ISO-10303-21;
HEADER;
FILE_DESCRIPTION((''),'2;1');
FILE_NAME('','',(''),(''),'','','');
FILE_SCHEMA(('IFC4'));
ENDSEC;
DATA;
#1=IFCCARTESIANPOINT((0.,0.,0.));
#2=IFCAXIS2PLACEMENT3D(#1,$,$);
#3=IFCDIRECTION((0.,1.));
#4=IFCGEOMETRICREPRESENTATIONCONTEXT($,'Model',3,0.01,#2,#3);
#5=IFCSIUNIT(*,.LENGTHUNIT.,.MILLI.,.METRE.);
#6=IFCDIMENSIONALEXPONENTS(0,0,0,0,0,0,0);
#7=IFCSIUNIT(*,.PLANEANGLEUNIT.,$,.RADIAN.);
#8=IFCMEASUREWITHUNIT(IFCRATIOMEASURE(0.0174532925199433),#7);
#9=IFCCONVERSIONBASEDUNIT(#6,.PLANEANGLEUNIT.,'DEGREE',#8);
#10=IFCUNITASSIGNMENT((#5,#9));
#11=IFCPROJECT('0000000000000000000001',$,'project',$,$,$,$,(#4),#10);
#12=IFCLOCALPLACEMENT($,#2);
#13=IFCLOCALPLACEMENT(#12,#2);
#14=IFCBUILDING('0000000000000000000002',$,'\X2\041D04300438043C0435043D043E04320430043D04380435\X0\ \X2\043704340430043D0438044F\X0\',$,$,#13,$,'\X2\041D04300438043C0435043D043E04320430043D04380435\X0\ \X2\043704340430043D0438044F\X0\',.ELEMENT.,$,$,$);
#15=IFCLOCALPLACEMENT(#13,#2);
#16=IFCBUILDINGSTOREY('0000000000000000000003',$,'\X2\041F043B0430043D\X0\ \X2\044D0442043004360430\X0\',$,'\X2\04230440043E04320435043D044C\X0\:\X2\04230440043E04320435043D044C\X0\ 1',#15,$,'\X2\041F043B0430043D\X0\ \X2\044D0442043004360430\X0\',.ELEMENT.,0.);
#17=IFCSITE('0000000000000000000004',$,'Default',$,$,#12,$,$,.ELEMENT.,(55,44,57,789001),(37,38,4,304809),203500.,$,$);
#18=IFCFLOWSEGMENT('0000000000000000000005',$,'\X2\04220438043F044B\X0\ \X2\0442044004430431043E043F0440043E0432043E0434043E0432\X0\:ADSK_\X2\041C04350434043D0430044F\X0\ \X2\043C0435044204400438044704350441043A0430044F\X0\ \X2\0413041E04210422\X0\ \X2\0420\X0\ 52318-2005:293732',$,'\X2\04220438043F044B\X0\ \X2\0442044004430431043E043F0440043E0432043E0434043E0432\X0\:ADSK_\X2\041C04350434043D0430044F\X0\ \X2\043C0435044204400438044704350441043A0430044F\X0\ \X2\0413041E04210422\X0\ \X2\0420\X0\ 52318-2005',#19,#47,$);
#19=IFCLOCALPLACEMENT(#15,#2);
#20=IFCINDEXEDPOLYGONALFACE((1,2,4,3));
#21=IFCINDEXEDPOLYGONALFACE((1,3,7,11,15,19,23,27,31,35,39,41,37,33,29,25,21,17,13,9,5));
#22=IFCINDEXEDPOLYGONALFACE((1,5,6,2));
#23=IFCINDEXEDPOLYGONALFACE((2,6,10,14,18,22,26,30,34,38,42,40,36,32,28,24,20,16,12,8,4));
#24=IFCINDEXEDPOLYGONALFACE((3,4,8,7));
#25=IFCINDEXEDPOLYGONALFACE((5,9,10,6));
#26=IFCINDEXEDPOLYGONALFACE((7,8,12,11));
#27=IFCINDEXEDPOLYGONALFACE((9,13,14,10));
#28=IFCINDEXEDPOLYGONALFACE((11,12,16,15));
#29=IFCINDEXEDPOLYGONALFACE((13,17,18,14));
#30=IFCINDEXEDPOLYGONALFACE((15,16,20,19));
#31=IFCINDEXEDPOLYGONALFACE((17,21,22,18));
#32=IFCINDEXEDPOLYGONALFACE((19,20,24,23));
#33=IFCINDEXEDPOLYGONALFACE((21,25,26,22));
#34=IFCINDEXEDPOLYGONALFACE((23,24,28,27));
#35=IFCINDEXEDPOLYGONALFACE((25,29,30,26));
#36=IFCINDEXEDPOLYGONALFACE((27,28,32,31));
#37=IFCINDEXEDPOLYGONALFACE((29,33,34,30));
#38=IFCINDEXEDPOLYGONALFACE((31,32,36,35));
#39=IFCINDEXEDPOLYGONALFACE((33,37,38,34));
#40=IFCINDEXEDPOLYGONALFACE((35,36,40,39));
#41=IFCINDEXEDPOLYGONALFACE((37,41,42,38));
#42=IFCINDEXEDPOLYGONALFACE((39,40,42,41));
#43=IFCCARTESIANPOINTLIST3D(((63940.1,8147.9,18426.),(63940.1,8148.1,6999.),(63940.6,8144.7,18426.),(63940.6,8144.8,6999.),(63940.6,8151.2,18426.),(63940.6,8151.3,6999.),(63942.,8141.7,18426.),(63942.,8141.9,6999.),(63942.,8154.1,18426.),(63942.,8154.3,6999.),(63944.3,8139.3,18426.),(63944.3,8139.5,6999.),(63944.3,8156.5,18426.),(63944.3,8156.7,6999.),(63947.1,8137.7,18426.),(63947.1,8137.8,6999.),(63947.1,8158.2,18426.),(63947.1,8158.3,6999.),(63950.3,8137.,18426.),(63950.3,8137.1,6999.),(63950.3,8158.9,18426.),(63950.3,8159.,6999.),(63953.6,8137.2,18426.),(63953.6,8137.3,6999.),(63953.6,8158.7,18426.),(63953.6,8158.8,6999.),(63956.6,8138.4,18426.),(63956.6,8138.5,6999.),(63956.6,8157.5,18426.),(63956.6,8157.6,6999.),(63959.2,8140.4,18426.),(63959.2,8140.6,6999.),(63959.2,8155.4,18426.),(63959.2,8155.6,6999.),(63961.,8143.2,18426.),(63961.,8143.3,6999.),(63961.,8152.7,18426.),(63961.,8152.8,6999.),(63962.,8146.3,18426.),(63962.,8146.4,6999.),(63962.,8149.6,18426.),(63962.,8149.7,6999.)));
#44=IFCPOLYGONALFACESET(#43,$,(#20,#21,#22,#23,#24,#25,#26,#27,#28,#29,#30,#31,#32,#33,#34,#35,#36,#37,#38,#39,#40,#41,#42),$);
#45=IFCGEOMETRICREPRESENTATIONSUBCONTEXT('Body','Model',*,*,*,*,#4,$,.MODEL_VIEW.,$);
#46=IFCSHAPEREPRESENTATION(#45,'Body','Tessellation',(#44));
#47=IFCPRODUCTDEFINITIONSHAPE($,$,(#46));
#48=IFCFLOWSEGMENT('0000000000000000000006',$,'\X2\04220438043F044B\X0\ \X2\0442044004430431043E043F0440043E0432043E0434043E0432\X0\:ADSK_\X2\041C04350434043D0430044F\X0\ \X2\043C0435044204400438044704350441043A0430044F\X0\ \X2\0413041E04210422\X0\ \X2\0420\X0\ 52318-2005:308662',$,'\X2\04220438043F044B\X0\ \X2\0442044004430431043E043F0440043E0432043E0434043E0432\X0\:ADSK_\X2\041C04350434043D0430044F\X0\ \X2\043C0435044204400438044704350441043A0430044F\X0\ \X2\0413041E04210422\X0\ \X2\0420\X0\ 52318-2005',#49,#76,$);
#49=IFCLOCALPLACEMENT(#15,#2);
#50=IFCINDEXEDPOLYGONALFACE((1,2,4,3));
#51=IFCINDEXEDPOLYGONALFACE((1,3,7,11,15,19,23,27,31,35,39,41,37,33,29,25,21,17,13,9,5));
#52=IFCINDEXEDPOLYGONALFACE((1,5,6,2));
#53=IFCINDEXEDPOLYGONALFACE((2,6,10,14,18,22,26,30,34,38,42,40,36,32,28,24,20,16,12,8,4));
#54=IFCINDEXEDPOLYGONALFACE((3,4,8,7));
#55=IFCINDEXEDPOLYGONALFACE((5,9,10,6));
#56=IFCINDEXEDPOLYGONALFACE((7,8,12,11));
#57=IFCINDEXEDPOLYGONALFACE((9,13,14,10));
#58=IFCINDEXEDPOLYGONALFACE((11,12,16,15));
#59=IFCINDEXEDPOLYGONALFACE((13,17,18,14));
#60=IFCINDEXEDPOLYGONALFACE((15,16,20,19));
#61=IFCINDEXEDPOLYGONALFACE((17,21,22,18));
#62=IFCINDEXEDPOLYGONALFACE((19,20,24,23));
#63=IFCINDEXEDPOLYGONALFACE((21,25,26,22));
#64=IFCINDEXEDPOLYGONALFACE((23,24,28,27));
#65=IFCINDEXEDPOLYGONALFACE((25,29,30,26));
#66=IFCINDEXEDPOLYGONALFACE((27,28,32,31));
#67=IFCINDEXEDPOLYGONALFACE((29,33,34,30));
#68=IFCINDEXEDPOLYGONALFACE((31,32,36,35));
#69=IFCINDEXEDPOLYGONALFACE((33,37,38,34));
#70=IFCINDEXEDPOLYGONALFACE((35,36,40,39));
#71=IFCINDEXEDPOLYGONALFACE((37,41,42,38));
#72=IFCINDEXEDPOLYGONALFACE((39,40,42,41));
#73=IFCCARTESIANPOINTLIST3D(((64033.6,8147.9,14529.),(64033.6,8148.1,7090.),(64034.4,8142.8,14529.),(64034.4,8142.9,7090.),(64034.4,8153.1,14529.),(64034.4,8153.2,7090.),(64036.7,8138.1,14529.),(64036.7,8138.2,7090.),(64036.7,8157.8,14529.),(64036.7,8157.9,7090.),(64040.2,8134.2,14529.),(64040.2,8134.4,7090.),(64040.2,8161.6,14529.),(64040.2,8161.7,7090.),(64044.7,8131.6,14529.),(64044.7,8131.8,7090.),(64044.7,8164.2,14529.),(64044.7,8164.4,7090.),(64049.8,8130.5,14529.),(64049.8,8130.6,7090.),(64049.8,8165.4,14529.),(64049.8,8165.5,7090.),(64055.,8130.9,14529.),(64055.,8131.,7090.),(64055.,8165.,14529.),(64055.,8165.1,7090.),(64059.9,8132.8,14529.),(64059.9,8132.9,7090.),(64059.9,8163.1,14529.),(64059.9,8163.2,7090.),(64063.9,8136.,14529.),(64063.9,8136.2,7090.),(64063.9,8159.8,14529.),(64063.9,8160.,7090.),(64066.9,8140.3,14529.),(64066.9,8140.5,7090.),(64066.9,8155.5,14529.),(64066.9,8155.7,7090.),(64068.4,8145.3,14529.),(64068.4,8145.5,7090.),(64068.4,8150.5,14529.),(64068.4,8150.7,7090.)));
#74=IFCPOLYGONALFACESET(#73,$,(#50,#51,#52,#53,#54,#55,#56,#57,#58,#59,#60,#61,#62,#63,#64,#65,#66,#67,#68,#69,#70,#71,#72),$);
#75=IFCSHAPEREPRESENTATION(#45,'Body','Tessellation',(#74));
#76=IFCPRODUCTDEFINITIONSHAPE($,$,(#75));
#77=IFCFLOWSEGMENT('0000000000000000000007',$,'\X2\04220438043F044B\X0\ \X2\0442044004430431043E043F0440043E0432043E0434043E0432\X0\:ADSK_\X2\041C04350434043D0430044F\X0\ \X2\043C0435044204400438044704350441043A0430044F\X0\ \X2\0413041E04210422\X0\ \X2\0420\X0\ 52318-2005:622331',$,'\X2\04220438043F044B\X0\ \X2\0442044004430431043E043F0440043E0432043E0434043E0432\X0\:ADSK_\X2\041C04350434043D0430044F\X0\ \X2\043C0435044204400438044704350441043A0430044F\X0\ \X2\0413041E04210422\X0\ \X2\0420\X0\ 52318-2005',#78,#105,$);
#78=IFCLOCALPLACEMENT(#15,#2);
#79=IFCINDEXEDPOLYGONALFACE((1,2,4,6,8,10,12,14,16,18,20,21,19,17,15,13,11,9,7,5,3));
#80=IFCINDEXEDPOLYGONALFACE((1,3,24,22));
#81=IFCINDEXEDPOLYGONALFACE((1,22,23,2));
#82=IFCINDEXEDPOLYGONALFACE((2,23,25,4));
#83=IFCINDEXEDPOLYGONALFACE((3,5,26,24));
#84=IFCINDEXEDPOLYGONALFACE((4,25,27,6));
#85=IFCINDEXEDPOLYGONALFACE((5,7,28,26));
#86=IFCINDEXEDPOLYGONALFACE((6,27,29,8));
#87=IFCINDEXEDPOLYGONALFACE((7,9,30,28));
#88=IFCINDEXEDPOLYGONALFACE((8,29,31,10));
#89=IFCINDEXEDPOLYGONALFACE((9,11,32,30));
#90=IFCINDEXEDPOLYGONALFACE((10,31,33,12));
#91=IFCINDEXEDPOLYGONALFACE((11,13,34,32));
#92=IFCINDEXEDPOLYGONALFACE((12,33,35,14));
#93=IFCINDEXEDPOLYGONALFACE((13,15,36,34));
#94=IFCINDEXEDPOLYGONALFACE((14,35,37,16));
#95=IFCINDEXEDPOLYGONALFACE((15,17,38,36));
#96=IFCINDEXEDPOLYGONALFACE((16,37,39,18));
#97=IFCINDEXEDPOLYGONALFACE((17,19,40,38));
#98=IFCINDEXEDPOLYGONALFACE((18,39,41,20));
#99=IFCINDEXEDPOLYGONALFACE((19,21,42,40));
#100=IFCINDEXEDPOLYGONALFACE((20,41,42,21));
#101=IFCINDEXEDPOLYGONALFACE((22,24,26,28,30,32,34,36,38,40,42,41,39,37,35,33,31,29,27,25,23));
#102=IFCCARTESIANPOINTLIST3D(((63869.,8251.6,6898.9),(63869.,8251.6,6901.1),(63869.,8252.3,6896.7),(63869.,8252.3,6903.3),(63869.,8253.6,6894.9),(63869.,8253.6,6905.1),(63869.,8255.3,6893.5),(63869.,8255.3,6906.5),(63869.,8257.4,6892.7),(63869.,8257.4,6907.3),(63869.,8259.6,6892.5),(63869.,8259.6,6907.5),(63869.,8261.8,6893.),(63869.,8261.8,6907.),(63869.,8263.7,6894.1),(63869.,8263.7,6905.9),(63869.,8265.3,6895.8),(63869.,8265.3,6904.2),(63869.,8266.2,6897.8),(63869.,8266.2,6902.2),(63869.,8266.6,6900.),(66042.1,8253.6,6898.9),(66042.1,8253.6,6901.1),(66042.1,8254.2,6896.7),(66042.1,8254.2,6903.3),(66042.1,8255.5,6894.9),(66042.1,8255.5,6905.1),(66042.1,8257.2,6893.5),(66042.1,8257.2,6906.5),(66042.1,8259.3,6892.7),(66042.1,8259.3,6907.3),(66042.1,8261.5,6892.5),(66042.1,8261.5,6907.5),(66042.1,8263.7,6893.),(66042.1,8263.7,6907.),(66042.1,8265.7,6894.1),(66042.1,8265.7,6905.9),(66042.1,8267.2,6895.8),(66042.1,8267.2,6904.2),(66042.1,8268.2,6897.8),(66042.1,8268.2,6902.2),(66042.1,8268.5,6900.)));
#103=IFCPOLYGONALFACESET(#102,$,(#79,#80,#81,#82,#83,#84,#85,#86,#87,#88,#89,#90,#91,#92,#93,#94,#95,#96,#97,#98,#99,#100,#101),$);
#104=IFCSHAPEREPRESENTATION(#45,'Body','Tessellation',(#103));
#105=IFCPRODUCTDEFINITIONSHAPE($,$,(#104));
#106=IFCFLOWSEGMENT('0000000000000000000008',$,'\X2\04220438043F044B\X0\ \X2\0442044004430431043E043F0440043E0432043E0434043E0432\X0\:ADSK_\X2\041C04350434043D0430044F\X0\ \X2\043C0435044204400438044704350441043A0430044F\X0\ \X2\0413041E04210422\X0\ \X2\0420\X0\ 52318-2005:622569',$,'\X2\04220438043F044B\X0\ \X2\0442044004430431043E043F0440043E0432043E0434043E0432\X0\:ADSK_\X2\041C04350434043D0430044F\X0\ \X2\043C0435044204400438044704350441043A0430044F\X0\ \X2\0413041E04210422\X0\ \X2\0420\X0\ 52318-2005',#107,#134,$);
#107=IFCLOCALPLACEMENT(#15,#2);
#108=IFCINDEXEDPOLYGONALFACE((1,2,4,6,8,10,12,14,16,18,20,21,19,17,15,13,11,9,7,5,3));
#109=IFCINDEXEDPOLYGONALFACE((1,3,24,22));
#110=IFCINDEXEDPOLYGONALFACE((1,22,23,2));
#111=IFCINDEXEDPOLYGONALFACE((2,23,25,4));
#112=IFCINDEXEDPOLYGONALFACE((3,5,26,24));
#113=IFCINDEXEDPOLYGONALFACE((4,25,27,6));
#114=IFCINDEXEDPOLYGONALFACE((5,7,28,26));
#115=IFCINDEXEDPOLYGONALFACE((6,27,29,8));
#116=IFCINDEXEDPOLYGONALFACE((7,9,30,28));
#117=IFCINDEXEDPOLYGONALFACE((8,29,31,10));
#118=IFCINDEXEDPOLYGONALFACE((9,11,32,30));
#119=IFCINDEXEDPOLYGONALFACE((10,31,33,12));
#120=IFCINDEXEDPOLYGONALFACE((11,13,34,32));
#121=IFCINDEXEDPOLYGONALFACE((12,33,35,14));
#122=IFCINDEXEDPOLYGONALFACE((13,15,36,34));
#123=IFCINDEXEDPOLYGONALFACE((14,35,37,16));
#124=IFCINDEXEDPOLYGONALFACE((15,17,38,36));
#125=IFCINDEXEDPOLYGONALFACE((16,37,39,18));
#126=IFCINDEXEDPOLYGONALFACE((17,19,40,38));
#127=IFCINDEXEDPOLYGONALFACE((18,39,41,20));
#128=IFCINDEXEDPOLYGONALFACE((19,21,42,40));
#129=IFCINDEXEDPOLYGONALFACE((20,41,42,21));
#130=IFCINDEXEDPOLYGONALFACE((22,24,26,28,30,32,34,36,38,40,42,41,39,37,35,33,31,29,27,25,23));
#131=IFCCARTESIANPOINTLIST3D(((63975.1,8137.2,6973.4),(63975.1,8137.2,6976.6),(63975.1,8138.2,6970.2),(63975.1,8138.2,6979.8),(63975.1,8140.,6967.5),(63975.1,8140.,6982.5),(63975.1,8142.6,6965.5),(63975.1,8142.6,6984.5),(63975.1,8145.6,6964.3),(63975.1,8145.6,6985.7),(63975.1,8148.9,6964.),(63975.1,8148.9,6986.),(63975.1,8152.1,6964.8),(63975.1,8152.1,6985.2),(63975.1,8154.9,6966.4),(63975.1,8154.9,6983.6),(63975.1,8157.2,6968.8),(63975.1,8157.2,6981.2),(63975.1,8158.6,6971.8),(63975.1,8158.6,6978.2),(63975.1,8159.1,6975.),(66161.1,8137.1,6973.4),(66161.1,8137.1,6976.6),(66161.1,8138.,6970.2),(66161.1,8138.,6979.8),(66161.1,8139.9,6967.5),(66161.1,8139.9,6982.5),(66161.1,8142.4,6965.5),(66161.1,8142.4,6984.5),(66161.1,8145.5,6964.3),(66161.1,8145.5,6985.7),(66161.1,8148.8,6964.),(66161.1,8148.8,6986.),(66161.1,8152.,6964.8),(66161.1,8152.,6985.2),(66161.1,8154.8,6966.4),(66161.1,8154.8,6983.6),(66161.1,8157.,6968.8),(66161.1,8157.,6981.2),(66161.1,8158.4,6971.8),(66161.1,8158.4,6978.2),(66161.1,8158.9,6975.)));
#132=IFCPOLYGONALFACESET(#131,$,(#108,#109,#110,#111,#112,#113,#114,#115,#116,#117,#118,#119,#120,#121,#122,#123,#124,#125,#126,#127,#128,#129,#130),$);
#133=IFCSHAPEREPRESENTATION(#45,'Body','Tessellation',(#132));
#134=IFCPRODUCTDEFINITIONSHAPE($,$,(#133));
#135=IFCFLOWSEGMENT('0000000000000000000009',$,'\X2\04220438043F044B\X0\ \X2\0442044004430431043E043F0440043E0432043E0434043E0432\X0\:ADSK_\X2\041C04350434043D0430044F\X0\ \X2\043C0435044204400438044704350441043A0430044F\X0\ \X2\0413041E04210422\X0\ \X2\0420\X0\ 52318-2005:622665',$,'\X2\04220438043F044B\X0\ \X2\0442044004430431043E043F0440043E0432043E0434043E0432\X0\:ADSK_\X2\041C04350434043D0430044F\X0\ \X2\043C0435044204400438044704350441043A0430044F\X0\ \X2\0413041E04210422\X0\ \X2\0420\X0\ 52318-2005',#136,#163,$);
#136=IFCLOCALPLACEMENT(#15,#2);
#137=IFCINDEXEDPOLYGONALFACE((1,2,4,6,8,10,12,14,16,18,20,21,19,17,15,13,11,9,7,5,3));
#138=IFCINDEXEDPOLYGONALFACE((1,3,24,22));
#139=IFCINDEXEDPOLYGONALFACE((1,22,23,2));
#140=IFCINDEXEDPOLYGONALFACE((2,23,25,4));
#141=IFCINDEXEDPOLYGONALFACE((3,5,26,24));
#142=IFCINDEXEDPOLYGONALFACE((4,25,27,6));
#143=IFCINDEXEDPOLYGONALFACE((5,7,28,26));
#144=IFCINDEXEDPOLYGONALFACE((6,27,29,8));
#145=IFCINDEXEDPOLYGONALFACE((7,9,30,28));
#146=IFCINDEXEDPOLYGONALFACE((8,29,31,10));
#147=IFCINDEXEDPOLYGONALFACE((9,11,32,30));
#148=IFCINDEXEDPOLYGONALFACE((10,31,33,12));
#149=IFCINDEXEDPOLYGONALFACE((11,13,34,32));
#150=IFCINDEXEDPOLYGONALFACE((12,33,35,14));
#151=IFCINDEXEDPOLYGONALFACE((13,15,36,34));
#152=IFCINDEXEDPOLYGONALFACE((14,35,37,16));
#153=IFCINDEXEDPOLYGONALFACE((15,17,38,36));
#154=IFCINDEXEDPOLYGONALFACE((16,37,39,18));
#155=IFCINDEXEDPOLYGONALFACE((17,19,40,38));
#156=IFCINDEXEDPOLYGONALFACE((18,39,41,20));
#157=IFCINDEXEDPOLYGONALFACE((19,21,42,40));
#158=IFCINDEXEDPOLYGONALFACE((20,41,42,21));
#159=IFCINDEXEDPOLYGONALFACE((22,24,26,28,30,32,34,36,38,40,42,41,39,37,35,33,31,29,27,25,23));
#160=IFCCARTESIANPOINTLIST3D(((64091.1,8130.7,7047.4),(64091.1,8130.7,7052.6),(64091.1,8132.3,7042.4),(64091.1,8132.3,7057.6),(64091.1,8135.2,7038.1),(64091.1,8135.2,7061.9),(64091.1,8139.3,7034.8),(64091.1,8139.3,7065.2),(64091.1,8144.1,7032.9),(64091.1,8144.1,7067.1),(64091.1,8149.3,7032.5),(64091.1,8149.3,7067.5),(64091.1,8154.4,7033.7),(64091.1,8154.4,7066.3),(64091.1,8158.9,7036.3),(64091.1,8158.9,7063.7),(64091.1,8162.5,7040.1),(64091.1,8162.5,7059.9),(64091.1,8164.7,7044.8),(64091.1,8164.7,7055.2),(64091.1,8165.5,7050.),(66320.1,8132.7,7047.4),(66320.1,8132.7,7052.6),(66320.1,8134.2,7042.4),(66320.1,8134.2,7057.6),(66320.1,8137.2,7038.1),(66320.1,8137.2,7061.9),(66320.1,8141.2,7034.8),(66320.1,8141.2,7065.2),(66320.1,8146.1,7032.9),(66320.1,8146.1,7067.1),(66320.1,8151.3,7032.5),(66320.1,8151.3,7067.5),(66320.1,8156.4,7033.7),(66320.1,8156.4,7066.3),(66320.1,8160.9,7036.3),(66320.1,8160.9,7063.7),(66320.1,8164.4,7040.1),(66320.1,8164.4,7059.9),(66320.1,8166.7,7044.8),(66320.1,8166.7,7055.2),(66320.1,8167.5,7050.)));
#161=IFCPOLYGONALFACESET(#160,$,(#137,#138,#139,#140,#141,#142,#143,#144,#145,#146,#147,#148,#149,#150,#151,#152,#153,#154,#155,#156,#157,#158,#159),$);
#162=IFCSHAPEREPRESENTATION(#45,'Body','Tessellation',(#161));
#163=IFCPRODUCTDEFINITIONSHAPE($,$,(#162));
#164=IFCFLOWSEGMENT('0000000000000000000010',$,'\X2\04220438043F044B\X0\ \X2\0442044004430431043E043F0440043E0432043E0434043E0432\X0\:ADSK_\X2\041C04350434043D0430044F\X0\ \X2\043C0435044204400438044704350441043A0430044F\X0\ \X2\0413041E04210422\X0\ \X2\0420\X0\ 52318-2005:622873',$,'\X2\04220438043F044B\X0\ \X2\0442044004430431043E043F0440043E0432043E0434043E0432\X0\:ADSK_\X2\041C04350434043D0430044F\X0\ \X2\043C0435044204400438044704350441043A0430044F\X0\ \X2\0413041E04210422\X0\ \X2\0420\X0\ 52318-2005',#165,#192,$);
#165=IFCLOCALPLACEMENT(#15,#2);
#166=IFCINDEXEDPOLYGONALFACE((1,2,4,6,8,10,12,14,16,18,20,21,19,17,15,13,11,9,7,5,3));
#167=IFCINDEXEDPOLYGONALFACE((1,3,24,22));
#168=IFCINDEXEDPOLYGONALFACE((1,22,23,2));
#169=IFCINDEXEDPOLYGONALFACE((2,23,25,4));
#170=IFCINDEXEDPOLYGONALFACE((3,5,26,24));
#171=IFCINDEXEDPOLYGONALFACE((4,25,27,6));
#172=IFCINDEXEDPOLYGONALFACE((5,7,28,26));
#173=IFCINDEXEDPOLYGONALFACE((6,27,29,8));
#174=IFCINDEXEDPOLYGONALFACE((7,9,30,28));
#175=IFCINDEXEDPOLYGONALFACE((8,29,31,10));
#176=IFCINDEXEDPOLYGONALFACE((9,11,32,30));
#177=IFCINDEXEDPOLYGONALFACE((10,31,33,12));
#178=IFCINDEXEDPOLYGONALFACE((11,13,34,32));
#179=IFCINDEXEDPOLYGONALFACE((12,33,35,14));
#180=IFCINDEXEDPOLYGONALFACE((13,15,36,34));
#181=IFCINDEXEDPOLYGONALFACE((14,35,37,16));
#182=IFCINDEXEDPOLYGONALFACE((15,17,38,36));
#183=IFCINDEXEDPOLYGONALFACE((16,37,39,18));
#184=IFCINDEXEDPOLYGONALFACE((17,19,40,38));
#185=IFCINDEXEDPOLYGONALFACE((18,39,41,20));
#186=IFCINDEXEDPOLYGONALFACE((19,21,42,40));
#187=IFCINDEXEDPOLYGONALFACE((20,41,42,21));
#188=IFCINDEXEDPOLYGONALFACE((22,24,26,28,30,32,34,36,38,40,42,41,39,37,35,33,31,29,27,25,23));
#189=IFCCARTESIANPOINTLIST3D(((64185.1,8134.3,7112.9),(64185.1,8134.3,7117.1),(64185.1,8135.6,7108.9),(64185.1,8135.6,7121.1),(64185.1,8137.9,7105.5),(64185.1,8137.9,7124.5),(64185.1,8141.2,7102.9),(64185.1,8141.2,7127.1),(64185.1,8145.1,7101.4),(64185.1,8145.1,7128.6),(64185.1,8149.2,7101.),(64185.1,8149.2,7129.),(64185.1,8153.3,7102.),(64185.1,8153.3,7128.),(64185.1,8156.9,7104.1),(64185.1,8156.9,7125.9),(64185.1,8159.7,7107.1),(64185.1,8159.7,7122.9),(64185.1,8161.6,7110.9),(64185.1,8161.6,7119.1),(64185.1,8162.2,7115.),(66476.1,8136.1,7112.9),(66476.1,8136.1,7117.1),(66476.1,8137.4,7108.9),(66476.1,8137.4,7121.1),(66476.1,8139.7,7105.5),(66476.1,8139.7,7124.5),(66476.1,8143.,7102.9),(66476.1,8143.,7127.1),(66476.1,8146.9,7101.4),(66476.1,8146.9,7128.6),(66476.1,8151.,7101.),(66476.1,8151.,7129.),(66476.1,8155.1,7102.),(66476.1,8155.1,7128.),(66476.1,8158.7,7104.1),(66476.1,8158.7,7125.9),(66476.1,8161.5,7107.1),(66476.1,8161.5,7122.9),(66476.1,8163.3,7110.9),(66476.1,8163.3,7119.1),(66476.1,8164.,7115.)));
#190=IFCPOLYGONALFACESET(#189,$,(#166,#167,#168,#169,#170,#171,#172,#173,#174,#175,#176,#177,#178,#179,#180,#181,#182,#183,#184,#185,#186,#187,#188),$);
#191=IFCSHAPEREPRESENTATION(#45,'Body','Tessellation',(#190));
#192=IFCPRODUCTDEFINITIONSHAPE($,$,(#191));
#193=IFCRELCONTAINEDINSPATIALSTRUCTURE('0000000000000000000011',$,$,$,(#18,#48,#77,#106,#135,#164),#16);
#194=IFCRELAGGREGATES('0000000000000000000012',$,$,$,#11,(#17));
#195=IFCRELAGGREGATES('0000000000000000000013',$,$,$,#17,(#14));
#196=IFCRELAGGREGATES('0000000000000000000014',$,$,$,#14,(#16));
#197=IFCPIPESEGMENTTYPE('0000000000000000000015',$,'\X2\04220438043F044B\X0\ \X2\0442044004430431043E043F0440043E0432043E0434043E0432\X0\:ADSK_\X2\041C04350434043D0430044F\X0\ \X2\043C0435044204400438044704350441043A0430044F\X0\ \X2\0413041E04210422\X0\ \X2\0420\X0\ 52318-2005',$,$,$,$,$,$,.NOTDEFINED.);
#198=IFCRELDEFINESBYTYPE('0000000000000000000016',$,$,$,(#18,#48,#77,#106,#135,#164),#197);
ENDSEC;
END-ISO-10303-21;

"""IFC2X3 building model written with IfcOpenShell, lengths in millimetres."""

from ifc_helpers import new_model, entity, si_unit, converted_unit, direction, frame, frame_2d, origin, origin_2d_with_axis, place, context, subcontext, project, spatial, circle, extrude, type_object, element, save


model = new_model("IFC2X3")

# Units and contexts
model_context = context("Model", 3, precision=0.01, world=origin(), true_north=direction((0.0, 1.0)))
body_context = subcontext(model_context, "Body", "Model", "MODEL_VIEW")
ifc_project = project(units=[si_unit("LENGTHUNIT", "METRE", prefix="MILLI"), converted_unit("PLANEANGLEUNIT", "DEGREE", entity("IfcRatioMeasure", 0.0174532925199433), si_unit("PLANEANGLEUNIT", "RADIAN"), dimensions=[0, 0, 0, 0, 0, 0, 0])], contexts=[model_context])

# Site, building, storey
site_placement = place(None, frame((0.0, 0.0, 0.0)))
site = spatial("IfcSite", under=ifc_project, at=site_placement, Name="Default", CompositionType="ELEMENT", RefLatitude=(55, 44, 57, 789001), RefLongitude=(37, 38, 4, 304809), RefElevation=203500.0)
building_placement = place(site_placement, origin())
building = spatial("IfcBuilding", under=site, at=building_placement, Name="Наименование здания", LongName="Наименование здания", CompositionType="ELEMENT")
storey_placement = place(building_placement, origin())
storey = spatial("IfcBuildingStorey", under=building, at=storey_placement, Name="План этажа", ObjectType="Уровень:Уровень 1", LongName="План этажа", CompositionType="ELEMENT", Elevation=0.0)

# Flow segments
pipe_segment_type = type_object("IfcPipeSegmentType", Name="Типы трубопроводов:ADSK_Медная метрическая ГОСТ Р 52318-2005", PredefinedType="NOTDEFINED")
flow_segment_1_placement = place(building_placement, frame((63938.5, 8135.3, 6999.0)))
element("IfcFlowSegment", 1, at=flow_segment_1_placement, inside=storey, type_object=pipe_segment_type, Name="Типы трубопроводов:ADSK_Медная метрическая ГОСТ Р 52318-2005:293732", ObjectType="Типы трубопроводов:ADSK_Медная метрическая ГОСТ Р 52318-2005", context=body_context, shape_type="SweptSolid", body=[
    extrude(circle(Radius=11.0, at=origin_2d_with_axis()), frame((12.6, 12.7, 0.0), z_axis=(0.0, -0.000012, 1.0), x_axis=(-1.0, 0.0, 0.0)), (0.0, 0.0, 1.0), 11427.0),
])
flow_segment_2_placement = place(building_placement, frame((64032.0, 8128.8, 7090.0)))
element("IfcFlowSegment", 2, at=flow_segment_2_placement, inside=storey, type_object=pipe_segment_type, Name="Типы трубопроводов:ADSK_Медная метрическая ГОСТ Р 52318-2005:308662", ObjectType="Типы трубопроводов:ADSK_Медная метрическая ГОСТ Р 52318-2005", context=body_context, shape_type="SweptSolid", body=[
    extrude(circle(Radius=17.5, at=origin_2d_with_axis()), frame((19.1, 19.2, 0.0), z_axis=(0.0, -0.000018, 1.0), x_axis=(-1.0, 0.0, 0.0)), (0.0, 0.0, 1.0), 7439.0),
])
flow_segment_3_placement = place(building_placement, frame((63869.0, 8250.0, 6890.9)))
element("IfcFlowSegment", 3, at=flow_segment_3_placement, inside=storey, type_object=pipe_segment_type, Name="Типы трубопроводов:ADSK_Медная метрическая ГОСТ Р 52318-2005:622331", ObjectType="Типы трубопроводов:ADSK_Медная метрическая ГОСТ Р 52318-2005", context=body_context, shape_type="SweptSolid", body=[
    extrude(circle(Radius=7.5, at=origin_2d_with_axis()), frame((0.0, 9.1, 9.1), z_axis=(1.0, 0.000887, 0.0), x_axis=(-0.000887, 1.0, 0.0)), (0.0, 0.0, 1.0), 2173.1),
])
flow_segment_4_placement = place(building_placement, frame((63975.1, 8135.3, 6962.4)))
element("IfcFlowSegment", 4, at=flow_segment_4_placement, inside=storey, type_object=pipe_segment_type, Name="Типы трубопроводов:ADSK_Медная метрическая ГОСТ Р 52318-2005:622569", ObjectType="Типы трубопроводов:ADSK_Медная метрическая ГОСТ Р 52318-2005", context=body_context, shape_type="SweptSolid", body=[
    extrude(circle(Radius=11.0, at=origin_2d_with_axis()), frame((0.0, 12.7, 12.6), z_axis=(1.0, -0.000063, 0.0), x_axis=(0.000063, 1.0, 0.0)), (0.0, 0.0, 1.0), 2186.0),
])
flow_segment_5_placement = place(building_placement, frame((64091.1, 8128.9, 7030.9)))
element("IfcFlowSegment", 5, at=flow_segment_5_placement, inside=storey, type_object=pipe_segment_type, Name="Типы трубопроводов:ADSK_Медная метрическая ГОСТ Р 52318-2005:622665", ObjectType="Типы трубопроводов:ADSK_Медная метрическая ГОСТ Р 52318-2005", context=body_context, shape_type="SweptSolid", body=[
    extrude(circle(Radius=17.5, at=origin_2d_with_axis()), frame((0.0, 19.1, 19.1), z_axis=(1.0, 0.000882, 0.0), x_axis=(-0.000882, 1.0, 0.0)), (0.0, 0.0, 1.0), 2229.0),
])
flow_segment_6_placement = place(building_placement, frame((64185.1, 8132.6, 7099.4)))
element("IfcFlowSegment", 6, at=flow_segment_6_placement, inside=storey, type_object=pipe_segment_type, Name="Типы трубопроводов:ADSK_Медная метрическая ГОСТ Р 52318-2005:622873", ObjectType="Типы трубопроводов:ADSK_Медная метрическая ГОСТ Р 52318-2005", context=body_context, shape_type="SweptSolid", body=[
    extrude(circle(Radius=14.0, at=frame_2d((0.0, 0.0), x_axis=(1.0, 0.0))), frame((0.0, 15.6, 15.6), z_axis=(1.0, 0.000782, 0.0), x_axis=(-0.000782, 1.0, 0.0)), (0.0, 0.0, 1.0), 2291.0),
])

save(model, "model.ifc")
